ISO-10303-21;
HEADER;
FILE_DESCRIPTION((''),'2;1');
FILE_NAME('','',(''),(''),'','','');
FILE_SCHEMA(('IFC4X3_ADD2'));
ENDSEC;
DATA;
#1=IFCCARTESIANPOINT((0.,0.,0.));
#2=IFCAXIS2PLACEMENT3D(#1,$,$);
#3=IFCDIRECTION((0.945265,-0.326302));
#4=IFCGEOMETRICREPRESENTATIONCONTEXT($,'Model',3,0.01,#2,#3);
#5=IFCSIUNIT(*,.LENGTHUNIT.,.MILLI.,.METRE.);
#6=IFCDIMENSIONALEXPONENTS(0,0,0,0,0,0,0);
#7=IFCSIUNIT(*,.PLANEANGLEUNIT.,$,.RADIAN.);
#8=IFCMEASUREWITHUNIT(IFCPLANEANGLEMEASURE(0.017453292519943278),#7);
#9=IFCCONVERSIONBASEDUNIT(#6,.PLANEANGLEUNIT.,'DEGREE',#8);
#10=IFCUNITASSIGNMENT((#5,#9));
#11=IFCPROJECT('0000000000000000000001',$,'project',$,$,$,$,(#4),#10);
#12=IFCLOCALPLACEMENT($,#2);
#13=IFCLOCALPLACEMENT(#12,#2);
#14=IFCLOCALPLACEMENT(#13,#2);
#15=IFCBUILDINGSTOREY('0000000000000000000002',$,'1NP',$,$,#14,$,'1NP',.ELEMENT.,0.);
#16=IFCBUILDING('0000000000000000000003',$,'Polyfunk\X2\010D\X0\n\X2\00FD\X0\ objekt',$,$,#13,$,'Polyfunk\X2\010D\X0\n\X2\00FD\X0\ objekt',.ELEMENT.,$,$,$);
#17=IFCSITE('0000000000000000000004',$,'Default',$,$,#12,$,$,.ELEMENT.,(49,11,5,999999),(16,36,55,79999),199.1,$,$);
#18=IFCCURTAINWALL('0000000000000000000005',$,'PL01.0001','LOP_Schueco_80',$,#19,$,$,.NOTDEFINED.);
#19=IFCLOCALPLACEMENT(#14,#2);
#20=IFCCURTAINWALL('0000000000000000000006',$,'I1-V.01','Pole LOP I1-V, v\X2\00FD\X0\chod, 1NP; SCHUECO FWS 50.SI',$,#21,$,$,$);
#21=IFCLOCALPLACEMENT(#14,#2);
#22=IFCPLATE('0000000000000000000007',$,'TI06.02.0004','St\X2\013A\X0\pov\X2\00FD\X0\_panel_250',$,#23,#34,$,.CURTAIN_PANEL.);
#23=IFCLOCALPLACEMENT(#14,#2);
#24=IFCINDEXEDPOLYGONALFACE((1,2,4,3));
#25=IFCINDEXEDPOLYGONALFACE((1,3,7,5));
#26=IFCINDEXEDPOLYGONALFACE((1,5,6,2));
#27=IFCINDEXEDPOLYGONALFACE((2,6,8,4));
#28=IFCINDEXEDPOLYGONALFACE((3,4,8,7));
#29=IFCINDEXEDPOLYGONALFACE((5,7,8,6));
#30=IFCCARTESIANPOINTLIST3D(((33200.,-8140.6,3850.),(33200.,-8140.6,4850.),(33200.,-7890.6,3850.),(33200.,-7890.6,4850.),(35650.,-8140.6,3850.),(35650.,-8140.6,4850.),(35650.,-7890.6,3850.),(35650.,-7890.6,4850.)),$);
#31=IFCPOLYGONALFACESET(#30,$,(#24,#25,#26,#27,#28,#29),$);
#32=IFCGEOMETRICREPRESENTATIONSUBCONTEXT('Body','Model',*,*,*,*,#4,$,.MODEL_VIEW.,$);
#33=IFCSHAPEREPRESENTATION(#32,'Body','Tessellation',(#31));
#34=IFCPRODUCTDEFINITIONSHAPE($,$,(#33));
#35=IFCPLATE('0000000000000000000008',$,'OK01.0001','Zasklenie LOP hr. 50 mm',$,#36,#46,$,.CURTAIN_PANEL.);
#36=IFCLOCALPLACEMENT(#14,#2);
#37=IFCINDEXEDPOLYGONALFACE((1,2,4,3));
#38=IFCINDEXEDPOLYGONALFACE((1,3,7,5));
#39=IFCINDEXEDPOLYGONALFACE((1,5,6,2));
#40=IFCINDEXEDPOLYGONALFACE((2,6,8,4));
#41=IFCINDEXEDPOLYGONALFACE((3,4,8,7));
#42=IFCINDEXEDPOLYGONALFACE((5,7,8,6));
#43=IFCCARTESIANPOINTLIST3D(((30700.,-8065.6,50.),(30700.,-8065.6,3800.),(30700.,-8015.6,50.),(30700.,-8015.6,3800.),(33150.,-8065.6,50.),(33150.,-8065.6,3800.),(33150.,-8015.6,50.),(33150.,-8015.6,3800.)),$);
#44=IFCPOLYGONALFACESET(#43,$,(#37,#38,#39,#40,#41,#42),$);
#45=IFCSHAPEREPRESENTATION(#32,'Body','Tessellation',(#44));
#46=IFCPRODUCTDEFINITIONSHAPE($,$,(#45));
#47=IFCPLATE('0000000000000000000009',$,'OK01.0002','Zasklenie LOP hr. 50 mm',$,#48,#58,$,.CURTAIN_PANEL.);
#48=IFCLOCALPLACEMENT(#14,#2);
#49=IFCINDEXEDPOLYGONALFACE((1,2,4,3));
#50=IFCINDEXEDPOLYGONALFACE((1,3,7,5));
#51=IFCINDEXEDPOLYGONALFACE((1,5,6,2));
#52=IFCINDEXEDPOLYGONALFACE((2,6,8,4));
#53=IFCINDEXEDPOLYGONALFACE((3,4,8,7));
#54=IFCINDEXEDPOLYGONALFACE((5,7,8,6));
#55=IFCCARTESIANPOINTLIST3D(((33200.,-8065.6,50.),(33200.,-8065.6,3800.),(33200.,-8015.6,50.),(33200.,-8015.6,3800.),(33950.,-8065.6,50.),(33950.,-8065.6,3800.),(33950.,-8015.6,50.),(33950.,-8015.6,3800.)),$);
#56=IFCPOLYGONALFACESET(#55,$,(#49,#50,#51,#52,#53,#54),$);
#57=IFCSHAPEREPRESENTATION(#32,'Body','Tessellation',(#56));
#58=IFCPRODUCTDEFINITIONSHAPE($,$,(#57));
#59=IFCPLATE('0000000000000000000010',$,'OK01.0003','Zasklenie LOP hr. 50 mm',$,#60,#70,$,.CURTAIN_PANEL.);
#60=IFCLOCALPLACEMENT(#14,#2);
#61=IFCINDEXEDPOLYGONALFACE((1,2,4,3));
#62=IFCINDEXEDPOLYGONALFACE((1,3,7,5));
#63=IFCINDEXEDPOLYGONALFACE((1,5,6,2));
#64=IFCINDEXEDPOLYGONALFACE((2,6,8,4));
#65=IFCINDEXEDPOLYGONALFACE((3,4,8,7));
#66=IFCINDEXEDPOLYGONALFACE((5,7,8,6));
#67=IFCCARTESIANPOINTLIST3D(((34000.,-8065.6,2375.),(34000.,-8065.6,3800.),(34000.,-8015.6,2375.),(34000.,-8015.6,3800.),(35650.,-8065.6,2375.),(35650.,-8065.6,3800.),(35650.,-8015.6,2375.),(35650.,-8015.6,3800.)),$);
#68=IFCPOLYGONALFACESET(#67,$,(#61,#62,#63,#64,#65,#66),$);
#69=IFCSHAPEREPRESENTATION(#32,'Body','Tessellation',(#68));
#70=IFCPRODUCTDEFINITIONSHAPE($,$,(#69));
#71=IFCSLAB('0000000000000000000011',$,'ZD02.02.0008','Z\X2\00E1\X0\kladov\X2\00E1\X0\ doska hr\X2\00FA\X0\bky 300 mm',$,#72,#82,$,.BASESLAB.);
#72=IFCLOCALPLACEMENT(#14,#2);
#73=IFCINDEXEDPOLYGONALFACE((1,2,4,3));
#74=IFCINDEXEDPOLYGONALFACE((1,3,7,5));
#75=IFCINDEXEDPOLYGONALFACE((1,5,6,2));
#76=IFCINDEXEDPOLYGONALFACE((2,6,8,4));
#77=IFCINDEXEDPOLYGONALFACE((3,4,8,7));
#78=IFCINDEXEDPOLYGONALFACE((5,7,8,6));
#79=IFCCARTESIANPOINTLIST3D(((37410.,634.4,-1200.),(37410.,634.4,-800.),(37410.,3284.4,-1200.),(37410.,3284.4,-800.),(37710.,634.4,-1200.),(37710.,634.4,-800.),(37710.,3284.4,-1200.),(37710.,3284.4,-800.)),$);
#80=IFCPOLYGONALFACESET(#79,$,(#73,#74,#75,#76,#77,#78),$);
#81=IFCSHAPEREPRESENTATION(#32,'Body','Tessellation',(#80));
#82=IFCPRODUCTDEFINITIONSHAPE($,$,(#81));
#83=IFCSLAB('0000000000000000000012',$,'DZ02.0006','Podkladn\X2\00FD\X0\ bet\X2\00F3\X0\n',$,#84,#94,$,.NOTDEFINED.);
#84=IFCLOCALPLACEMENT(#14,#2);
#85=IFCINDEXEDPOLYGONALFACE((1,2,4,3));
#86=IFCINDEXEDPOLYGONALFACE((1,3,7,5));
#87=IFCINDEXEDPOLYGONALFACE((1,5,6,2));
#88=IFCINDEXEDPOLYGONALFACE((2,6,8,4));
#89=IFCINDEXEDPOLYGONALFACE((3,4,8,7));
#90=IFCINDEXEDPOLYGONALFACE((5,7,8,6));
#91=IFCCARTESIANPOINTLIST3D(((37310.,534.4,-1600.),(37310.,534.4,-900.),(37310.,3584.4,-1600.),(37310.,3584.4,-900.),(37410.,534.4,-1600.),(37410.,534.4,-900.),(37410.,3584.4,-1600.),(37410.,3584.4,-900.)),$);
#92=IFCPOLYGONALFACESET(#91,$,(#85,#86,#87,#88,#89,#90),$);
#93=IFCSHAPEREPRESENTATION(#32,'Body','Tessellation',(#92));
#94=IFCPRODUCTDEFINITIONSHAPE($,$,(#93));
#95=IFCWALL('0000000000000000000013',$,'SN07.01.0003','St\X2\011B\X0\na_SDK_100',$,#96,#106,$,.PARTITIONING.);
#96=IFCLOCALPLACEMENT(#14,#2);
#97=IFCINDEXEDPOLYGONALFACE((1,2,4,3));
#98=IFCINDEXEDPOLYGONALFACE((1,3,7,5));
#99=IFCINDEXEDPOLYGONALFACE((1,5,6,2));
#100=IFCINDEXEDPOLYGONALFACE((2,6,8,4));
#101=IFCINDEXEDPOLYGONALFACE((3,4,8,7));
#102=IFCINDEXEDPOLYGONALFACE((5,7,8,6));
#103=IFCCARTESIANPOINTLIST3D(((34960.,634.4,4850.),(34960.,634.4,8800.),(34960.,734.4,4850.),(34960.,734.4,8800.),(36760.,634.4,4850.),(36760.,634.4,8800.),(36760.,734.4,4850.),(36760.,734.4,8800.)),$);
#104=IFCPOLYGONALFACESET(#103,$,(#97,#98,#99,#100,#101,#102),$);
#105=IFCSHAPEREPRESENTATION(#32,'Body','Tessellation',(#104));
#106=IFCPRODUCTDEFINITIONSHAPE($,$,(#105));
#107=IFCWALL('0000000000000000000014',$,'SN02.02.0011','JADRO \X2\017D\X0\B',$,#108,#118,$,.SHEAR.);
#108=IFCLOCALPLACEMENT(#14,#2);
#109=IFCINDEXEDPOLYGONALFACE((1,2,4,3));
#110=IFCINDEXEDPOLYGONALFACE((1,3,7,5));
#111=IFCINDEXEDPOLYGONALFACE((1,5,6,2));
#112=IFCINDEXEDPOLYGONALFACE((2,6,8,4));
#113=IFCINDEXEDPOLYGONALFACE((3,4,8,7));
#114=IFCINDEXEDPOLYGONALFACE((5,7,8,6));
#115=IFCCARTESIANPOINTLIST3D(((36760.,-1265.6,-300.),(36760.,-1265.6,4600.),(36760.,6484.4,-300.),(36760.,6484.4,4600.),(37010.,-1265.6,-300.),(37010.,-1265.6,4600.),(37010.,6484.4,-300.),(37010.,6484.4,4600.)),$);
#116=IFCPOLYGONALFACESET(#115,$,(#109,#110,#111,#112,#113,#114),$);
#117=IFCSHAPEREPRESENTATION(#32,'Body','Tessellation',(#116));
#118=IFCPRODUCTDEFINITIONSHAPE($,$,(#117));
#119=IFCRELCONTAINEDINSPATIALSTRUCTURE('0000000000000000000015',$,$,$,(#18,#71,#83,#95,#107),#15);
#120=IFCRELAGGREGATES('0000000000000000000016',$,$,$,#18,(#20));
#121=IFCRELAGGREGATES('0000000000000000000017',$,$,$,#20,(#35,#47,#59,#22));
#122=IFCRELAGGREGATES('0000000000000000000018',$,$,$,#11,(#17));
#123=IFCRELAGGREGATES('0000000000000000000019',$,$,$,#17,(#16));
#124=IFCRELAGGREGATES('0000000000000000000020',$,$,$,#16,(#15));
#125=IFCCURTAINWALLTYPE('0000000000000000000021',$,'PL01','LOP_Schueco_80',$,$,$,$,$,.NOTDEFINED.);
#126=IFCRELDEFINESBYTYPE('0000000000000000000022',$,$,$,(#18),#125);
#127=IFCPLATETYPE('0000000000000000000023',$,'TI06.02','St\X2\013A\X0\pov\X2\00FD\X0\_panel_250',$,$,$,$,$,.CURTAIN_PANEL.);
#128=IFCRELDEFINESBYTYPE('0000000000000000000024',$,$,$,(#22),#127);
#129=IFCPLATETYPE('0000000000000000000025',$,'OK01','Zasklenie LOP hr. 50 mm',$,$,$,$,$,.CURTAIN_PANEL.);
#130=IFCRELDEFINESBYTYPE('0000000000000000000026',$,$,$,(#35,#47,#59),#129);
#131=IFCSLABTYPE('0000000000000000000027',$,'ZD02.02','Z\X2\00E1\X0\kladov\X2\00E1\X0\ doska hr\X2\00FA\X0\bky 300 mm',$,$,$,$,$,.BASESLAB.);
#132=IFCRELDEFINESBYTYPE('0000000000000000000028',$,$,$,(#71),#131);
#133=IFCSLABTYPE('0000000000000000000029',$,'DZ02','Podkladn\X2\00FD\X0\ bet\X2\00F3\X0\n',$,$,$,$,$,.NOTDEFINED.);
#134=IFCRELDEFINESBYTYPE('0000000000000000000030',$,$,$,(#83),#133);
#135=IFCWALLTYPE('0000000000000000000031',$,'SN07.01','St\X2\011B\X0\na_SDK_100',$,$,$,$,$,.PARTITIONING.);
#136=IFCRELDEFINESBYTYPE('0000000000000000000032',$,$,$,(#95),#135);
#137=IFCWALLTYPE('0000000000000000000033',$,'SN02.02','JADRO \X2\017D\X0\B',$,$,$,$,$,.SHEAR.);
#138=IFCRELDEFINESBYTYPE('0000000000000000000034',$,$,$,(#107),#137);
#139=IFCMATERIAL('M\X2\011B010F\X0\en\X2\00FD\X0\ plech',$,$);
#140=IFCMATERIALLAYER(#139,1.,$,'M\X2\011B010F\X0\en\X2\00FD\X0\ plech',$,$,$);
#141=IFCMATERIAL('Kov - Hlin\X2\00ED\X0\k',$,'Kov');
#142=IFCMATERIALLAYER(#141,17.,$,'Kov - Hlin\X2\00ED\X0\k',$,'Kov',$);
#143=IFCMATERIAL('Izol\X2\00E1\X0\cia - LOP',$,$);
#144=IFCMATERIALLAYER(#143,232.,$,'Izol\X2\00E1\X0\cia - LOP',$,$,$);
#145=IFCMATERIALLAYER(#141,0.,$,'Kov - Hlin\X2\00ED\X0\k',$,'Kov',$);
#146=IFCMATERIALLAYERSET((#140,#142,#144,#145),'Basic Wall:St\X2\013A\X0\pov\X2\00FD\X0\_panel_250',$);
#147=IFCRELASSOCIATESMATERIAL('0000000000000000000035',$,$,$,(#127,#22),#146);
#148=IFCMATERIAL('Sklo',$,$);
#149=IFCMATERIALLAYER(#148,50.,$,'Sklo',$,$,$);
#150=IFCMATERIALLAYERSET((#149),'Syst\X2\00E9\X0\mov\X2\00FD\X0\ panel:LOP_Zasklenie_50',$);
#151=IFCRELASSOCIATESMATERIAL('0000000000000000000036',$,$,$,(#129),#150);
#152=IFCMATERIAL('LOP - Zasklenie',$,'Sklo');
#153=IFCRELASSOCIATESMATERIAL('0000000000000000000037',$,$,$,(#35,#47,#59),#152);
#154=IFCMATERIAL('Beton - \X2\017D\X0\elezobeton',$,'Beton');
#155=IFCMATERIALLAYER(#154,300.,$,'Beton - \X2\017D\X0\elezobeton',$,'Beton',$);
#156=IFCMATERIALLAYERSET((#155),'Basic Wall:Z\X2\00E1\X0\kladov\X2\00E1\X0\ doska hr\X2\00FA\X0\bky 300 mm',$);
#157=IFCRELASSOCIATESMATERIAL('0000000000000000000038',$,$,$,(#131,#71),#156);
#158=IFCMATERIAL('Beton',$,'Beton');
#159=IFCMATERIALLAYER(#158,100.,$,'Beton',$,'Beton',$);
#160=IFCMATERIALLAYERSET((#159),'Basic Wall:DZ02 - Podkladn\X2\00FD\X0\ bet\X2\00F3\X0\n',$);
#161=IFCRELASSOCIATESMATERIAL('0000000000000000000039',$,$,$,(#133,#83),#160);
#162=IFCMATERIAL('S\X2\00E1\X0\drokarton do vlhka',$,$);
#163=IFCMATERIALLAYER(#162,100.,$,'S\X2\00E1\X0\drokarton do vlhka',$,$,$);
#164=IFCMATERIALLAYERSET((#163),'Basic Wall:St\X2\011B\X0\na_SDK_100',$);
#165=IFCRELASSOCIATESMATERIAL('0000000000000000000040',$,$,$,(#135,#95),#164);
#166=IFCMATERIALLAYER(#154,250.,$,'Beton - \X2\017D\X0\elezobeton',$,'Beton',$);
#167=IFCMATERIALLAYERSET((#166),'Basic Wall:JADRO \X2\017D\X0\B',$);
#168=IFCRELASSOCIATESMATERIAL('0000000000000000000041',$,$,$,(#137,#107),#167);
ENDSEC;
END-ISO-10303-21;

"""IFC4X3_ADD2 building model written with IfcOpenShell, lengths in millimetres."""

from ifc_helpers import new_model, entity, si_unit, converted_unit, direction, frame, frame_2d, origin, place, context, subcontext, project, spatial, polyline, rectangle, extrude, clip, bounded_halfspace, source, transform, mapped, material, layer, layer_set, layer_usage, type_object, type_shapes, element, aggregate, save


model = new_model("IFC4X3_ADD2")

# Units and contexts
model_context = context("Model", 3, precision=0.01, world=origin(), true_north=direction((0.945265, -0.326302)))
body_context = subcontext(model_context, "Body", "Model", "MODEL_VIEW")
ifc_project = project(units=[si_unit("LENGTHUNIT", "METRE", prefix="MILLI"), converted_unit("PLANEANGLEUNIT", "DEGREE", entity("IfcPlaneAngleMeasure", 0.017453292519943278), si_unit("PLANEANGLEUNIT", "RADIAN"), dimensions=[0, 0, 0, 0, 0, 0, 0])], contexts=[model_context])

# Site, building, storey
site_placement = place(None, origin())
site = spatial("IfcSite", under=ifc_project, at=site_placement, Name="Default", CompositionType="ELEMENT", RefLatitude=(49, 11, 5, 999999), RefLongitude=(16, 36, 55, 79999), RefElevation=199.1)
building_placement = place(site_placement, origin())
building = spatial("IfcBuilding", under=site, at=building_placement, Name="Polyfunkčný objekt", LongName="Polyfunkčný objekt", CompositionType="ELEMENT")
storey_placement = place(building_placement, origin())
storey = spatial("IfcBuildingStorey", under=building, at=storey_placement, Name="1NP", LongName="1NP", CompositionType="ELEMENT", Elevation=0.0)

# Curtain walls, plates
curtain_wall_type = type_object("IfcCurtainWallType", Name="PL01", Description="LOP_Schueco_80", PredefinedType="NOTDEFINED")
curtain_wall_1_placement = place(storey_placement, origin())
curtain_wall_1 = element("IfcCurtainWall", 1, at=curtain_wall_1_placement, inside=storey, type_object=curtain_wall_type, Name="PL01.0001", Description="LOP_Schueco_80", PredefinedType="NOTDEFINED")
curtain_wall_2 = element("IfcCurtainWall", 2, Name="I1-V.01", Description="Pole LOP I1-V, východ, 1NP; SCHUECO FWS 50.SI")
aggregate(curtain_wall_1, [curtain_wall_2])
ifc_material_1 = material(Name="Měďený plech")
ifc_layer_1 = layer(ifc_material_1, 1.0, Name="Měďený plech")
ifc_material_2 = material(Name="Kov - Hliník", Category="Kov")
ifc_layer_2 = layer(ifc_material_2, 17.0, Name="Kov - Hliník", Category="Kov")
ifc_material_3 = material(Name="Izolácia - LOP")
ifc_layer_3 = layer(ifc_material_3, 232.0, Name="Izolácia - LOP")
ifc_layer_4 = layer(ifc_material_2, 0.0, Name="Kov - Hliník", Category="Kov")
ifc_layer_set_1 = layer_set([ifc_layer_1, ifc_layer_2, ifc_layer_3, ifc_layer_4], Name="Basic Wall:Stĺpový_panel_250")
ifc_layer_usage_1 = layer_usage(ifc_layer_set_1, "AXIS2", "POSITIVE", -125.0)
plate_type_1 = type_object("IfcPlateType", Name="TI06.02", Description="Stĺpový_panel_250", PredefinedType="CURTAIN_PANEL", material=ifc_layer_set_1)
plate_1_placement = place(storey_placement, frame((33200.0, -8015.6, 3850.0)))
plate_1 = element("IfcPlate", 3, at=plate_1_placement, type_object=plate_type_1, material=ifc_layer_usage_1, Name="TI06.02.0004", Description="Stĺpový_panel_250", PredefinedType="CURTAIN_PANEL", context=body_context, shape_type="SweptSolid", body=[
    extrude(rectangle(XDim=250.0, YDim=2450.0, at=frame_2d((0.0, 0.0), x_axis=(1.0, 0.0))), frame((1225.0, 0.0, 0.0), z_axis=(0.0, 0.0, 1.0), x_axis=(0.0, 1.0, 0.0)), (0.0, 0.0, 1.0), 1000.0),
])
ifc_material_4 = material(Name="LOP - Zasklenie", Category="Sklo")
ifc_material_5 = material(Name="Sklo")
ifc_layer_5 = layer(ifc_material_5, 50.0, Name="Sklo")
ifc_layer_set_2 = layer_set([ifc_layer_5], Name="Systémový panel:LOP_Zasklenie_50")
plate_type_2 = type_object("IfcPlateType", Name="OK01", Description="Zasklenie LOP hr. 50 mm", PredefinedType="CURTAIN_PANEL", material=ifc_layer_set_2)
shared_shape_1 = source(origin(), body_context, "Body", "SweptSolid", [
    extrude(rectangle(XDim=3750.0, YDim=2450.0, at=frame_2d((-331.2, 0.0), x_axis=(1.0, 0.0))), frame((0.0, -50.0, 2206.2), z_axis=(0.0, 1.0, 0.0), x_axis=(0.0, 0.0, 1.0)), (0.0, 0.0, 1.0), 50.0),
])
plate_2_placement = place(curtain_wall_1_placement, frame((31925.0, -8015.6, 50.0)))
plate_2 = element("IfcPlate", 4, at=plate_2_placement, type_object=plate_type_2, material=ifc_material_4, Name="OK01.0001", Description="Zasklenie LOP hr. 50 mm", PredefinedType="CURTAIN_PANEL", context=body_context, shape_type="MappedRepresentation", body=[
    mapped(shared_shape_1, transform((0.0, 0.0, 0.0), scale=1.0)),
])
shared_shape_2 = source(origin(), body_context, "Body", "SweptSolid", [
    extrude(rectangle(XDim=3750.0, YDim=750.0, at=frame_2d((-331.2, 0.0), x_axis=(1.0, 0.0))), frame((0.0, -50.0, 2206.2), z_axis=(0.0, 1.0, 0.0), x_axis=(0.0, 0.0, 1.0)), (0.0, 0.0, 1.0), 50.0),
])
plate_3_placement = place(curtain_wall_1_placement, frame((33575.0, -8015.6, 50.0)))
plate_3 = element("IfcPlate", 5, at=plate_3_placement, type_object=plate_type_2, material=ifc_material_4, Name="OK01.0002", Description="Zasklenie LOP hr. 50 mm", PredefinedType="CURTAIN_PANEL", context=body_context, shape_type="MappedRepresentation", body=[
    mapped(shared_shape_2, transform((0.0, 0.0, 0.0), scale=1.0)),
])
shared_shape_3 = source(origin(), body_context, "Body", "SweptSolid", [
    extrude(rectangle(XDim=1425.0, YDim=1650.0, at=frame_2d((87.6, 0.0), x_axis=(1.0, 0.0))), frame((0.0, -50.0, 624.9), z_axis=(0.0, 1.0, 0.0), x_axis=(0.0, 0.0, 1.0)), (0.0, 0.0, 1.0), 50.0),
])
type_shapes(plate_type_2, [shared_shape_1, shared_shape_2, shared_shape_3])
plate_4_placement = place(curtain_wall_1_placement, frame((34825.0, -8015.6, 2375.0)))
plate_4 = element("IfcPlate", 6, at=plate_4_placement, type_object=plate_type_2, material=ifc_material_4, Name="OK01.0003", Description="Zasklenie LOP hr. 50 mm", PredefinedType="CURTAIN_PANEL", context=body_context, shape_type="MappedRepresentation", body=[
    mapped(shared_shape_3, transform((0.0, 0.0, 0.0), scale=1.0)),
])
aggregate(curtain_wall_2, [plate_2, plate_3, plate_4, plate_1])

# Slabs
ifc_material_6 = material(Name="Beton - Železobeton", Category="Beton")
ifc_layer_6 = layer(ifc_material_6, 300.0, Name="Beton - Železobeton", Category="Beton")
ifc_layer_set_3 = layer_set([ifc_layer_6], Name="Basic Wall:Základová doska hrúbky 300 mm")
slab_type_1 = type_object("IfcSlabType", Name="ZD02.02", Description="Základová doska hrúbky 300 mm", PredefinedType="BASESLAB", material=ifc_layer_set_3)
slab_1_placement = place(storey_placement, frame((37560.0, 634.4, -1200.0), z_axis=(0.0, 0.0, 1.0), x_axis=(0.0, 1.0, 0.0)))
element("IfcSlab", 7, at=slab_1_placement, inside=storey, type_object=slab_type_1, material=ifc_layer_set_3, Name="ZD02.02.0008", Description="Základová doska hrúbky 300 mm", PredefinedType="BASESLAB", context=body_context, shape_type="SweptSolid", body=[
    extrude(rectangle(XDim=2650.0, YDim=300.0, at=frame_2d((1325.0, 0.0), x_axis=(-1.0, 0.0))), origin(), (0.0, 0.0, 1.0), 400.0),
])
ifc_material_7 = material(Name="Beton", Category="Beton")
ifc_layer_7 = layer(ifc_material_7, 100.0, Name="Beton", Category="Beton")
ifc_layer_set_4 = layer_set([ifc_layer_7], Name="Basic Wall:DZ02 - Podkladný betón")
slab_type_2 = type_object("IfcSlabType", Name="DZ02", Description="Podkladný betón", PredefinedType="NOTDEFINED", material=ifc_layer_set_4)
slab_2_placement = place(storey_placement, frame((37360.0, 534.4, -1600.0), z_axis=(0.0, 0.0, 1.0), x_axis=(0.0, 1.0, 0.0)))
element("IfcSlab", 8, at=slab_2_placement, inside=storey, type_object=slab_type_2, material=ifc_layer_set_4, Name="DZ02.0006", Description="Podkladný betón", PredefinedType="NOTDEFINED", context=body_context, shape_type="SweptSolid", body=[
    extrude(rectangle(XDim=3050.0, YDim=100.0, at=frame_2d((1525.0, 0.0), x_axis=(-1.0, 0.0))), origin(), (0.0, 0.0, 1.0), 700.0),
])

# Walls
ifc_material_8 = material(Name="Sádrokarton do vlhka")
ifc_layer_8 = layer(ifc_material_8, 100.0, Name="Sádrokarton do vlhka")
ifc_layer_set_5 = layer_set([ifc_layer_8], Name="Basic Wall:Stěna_SDK_100")
wall_type_1 = type_object("IfcWallType", Name="SN07.01", Description="Stěna_SDK_100", PredefinedType="PARTITIONING", material=ifc_layer_set_5)
wall_1_placement = place(storey_placement, frame((34960.0, 684.4, 4850.0)))
element("IfcWall", 9, at=wall_1_placement, inside=storey, type_object=wall_type_1, material=ifc_layer_set_5, Name="SN07.01.0003", Description="Stěna_SDK_100", PredefinedType="PARTITIONING", context=body_context, shape_type="Clipping", body=[
    clip(clip(extrude(rectangle(XDim=1800.0, YDim=100.0, at=frame_2d((900.0, 0.0), x_axis=(-1.0, 0.0))), origin(), (0.0, 0.0, 1.0), 3950.0), bounded_halfspace(frame((1800.0, -50.0, 0.0), z_axis=(0.0, 0.0, 1.0), x_axis=(-1.0, 0.0, 0.0)), True, frame((1800.0, -50.0, 0.0)), polyline([(0.0, 0.0), (0.0, 100.0), (-1800.0, 100.0), (-1800.0, 0.0), (0.0, 0.0)]))), bounded_halfspace(frame((0.0, -50.0, 3950.0), z_axis=(0.0, 0.0, -1.0), x_axis=(1.0, 0.0, 0.0)), True, frame((0.0, -50.0, 3950.0)), polyline([(0.0, 0.0), (1800.0, 0.0), (1800.0, 100.0), (0.0, 100.0), (0.0, 0.0)]))),
])
ifc_layer_9 = layer(ifc_material_6, 250.0, Name="Beton - Železobeton", Category="Beton")
ifc_layer_set_6 = layer_set([ifc_layer_9], Name="Basic Wall:JADRO ŽB")
wall_type_2 = type_object("IfcWallType", Name="SN02.02", Description="JADRO ŽB", PredefinedType="SHEAR", material=ifc_layer_set_6)
wall_2_placement = place(storey_placement, frame((36885.0, -1265.6, -300.0), z_axis=(0.0, 0.0, 1.0), x_axis=(0.0, 1.0, 0.0)))
element("IfcWall", 10, at=wall_2_placement, inside=storey, type_object=wall_type_2, material=ifc_layer_set_6, Name="SN02.02.0011", Description="JADRO ŽB", PredefinedType="SHEAR", context=body_context, shape_type="Clipping", body=[
    clip(clip(extrude(rectangle(XDim=7750.0, YDim=250.0, at=frame_2d((3875.0, 0.0), x_axis=(-1.0, 0.0))), origin(), (0.0, 0.0, 1.0), 4900.0), bounded_halfspace(frame((7750.0, 125.0, 4900.0), z_axis=(0.0, 0.0, -1.0), x_axis=(0.0, -1.0, 0.0)), True, frame((7750.0, 125.0, 4900.0)), polyline([(0.0, 0.0), (-7750.0, 0.0), (-7750.0, -250.0), (-7500.0, -250.0), (-5800.0, -250.0), (-5550.0, -250.0), (-3200.0, -250.0), (-2950.0, -250.0), (-250.0, -250.0), (0.0, -250.0), (0.0, 0.0)]))), bounded_halfspace(frame((7750.0, -125.0, 0.0)), True, frame((7750.0, -125.0, 0.0)), polyline([(0.0, 0.0), (0.0, 250.0), (-390.0, 250.0), (-7750.0, 250.0), (-7750.0, 0.0), (-7500.0, 0.0), (-5800.0, 0.0), (-5550.0, 0.0), (-3200.0, 0.0), (-2950.0, 0.0), (-250.0, 0.0), (0.0, 0.0)]))),
])

save(model, "model.ifc")
